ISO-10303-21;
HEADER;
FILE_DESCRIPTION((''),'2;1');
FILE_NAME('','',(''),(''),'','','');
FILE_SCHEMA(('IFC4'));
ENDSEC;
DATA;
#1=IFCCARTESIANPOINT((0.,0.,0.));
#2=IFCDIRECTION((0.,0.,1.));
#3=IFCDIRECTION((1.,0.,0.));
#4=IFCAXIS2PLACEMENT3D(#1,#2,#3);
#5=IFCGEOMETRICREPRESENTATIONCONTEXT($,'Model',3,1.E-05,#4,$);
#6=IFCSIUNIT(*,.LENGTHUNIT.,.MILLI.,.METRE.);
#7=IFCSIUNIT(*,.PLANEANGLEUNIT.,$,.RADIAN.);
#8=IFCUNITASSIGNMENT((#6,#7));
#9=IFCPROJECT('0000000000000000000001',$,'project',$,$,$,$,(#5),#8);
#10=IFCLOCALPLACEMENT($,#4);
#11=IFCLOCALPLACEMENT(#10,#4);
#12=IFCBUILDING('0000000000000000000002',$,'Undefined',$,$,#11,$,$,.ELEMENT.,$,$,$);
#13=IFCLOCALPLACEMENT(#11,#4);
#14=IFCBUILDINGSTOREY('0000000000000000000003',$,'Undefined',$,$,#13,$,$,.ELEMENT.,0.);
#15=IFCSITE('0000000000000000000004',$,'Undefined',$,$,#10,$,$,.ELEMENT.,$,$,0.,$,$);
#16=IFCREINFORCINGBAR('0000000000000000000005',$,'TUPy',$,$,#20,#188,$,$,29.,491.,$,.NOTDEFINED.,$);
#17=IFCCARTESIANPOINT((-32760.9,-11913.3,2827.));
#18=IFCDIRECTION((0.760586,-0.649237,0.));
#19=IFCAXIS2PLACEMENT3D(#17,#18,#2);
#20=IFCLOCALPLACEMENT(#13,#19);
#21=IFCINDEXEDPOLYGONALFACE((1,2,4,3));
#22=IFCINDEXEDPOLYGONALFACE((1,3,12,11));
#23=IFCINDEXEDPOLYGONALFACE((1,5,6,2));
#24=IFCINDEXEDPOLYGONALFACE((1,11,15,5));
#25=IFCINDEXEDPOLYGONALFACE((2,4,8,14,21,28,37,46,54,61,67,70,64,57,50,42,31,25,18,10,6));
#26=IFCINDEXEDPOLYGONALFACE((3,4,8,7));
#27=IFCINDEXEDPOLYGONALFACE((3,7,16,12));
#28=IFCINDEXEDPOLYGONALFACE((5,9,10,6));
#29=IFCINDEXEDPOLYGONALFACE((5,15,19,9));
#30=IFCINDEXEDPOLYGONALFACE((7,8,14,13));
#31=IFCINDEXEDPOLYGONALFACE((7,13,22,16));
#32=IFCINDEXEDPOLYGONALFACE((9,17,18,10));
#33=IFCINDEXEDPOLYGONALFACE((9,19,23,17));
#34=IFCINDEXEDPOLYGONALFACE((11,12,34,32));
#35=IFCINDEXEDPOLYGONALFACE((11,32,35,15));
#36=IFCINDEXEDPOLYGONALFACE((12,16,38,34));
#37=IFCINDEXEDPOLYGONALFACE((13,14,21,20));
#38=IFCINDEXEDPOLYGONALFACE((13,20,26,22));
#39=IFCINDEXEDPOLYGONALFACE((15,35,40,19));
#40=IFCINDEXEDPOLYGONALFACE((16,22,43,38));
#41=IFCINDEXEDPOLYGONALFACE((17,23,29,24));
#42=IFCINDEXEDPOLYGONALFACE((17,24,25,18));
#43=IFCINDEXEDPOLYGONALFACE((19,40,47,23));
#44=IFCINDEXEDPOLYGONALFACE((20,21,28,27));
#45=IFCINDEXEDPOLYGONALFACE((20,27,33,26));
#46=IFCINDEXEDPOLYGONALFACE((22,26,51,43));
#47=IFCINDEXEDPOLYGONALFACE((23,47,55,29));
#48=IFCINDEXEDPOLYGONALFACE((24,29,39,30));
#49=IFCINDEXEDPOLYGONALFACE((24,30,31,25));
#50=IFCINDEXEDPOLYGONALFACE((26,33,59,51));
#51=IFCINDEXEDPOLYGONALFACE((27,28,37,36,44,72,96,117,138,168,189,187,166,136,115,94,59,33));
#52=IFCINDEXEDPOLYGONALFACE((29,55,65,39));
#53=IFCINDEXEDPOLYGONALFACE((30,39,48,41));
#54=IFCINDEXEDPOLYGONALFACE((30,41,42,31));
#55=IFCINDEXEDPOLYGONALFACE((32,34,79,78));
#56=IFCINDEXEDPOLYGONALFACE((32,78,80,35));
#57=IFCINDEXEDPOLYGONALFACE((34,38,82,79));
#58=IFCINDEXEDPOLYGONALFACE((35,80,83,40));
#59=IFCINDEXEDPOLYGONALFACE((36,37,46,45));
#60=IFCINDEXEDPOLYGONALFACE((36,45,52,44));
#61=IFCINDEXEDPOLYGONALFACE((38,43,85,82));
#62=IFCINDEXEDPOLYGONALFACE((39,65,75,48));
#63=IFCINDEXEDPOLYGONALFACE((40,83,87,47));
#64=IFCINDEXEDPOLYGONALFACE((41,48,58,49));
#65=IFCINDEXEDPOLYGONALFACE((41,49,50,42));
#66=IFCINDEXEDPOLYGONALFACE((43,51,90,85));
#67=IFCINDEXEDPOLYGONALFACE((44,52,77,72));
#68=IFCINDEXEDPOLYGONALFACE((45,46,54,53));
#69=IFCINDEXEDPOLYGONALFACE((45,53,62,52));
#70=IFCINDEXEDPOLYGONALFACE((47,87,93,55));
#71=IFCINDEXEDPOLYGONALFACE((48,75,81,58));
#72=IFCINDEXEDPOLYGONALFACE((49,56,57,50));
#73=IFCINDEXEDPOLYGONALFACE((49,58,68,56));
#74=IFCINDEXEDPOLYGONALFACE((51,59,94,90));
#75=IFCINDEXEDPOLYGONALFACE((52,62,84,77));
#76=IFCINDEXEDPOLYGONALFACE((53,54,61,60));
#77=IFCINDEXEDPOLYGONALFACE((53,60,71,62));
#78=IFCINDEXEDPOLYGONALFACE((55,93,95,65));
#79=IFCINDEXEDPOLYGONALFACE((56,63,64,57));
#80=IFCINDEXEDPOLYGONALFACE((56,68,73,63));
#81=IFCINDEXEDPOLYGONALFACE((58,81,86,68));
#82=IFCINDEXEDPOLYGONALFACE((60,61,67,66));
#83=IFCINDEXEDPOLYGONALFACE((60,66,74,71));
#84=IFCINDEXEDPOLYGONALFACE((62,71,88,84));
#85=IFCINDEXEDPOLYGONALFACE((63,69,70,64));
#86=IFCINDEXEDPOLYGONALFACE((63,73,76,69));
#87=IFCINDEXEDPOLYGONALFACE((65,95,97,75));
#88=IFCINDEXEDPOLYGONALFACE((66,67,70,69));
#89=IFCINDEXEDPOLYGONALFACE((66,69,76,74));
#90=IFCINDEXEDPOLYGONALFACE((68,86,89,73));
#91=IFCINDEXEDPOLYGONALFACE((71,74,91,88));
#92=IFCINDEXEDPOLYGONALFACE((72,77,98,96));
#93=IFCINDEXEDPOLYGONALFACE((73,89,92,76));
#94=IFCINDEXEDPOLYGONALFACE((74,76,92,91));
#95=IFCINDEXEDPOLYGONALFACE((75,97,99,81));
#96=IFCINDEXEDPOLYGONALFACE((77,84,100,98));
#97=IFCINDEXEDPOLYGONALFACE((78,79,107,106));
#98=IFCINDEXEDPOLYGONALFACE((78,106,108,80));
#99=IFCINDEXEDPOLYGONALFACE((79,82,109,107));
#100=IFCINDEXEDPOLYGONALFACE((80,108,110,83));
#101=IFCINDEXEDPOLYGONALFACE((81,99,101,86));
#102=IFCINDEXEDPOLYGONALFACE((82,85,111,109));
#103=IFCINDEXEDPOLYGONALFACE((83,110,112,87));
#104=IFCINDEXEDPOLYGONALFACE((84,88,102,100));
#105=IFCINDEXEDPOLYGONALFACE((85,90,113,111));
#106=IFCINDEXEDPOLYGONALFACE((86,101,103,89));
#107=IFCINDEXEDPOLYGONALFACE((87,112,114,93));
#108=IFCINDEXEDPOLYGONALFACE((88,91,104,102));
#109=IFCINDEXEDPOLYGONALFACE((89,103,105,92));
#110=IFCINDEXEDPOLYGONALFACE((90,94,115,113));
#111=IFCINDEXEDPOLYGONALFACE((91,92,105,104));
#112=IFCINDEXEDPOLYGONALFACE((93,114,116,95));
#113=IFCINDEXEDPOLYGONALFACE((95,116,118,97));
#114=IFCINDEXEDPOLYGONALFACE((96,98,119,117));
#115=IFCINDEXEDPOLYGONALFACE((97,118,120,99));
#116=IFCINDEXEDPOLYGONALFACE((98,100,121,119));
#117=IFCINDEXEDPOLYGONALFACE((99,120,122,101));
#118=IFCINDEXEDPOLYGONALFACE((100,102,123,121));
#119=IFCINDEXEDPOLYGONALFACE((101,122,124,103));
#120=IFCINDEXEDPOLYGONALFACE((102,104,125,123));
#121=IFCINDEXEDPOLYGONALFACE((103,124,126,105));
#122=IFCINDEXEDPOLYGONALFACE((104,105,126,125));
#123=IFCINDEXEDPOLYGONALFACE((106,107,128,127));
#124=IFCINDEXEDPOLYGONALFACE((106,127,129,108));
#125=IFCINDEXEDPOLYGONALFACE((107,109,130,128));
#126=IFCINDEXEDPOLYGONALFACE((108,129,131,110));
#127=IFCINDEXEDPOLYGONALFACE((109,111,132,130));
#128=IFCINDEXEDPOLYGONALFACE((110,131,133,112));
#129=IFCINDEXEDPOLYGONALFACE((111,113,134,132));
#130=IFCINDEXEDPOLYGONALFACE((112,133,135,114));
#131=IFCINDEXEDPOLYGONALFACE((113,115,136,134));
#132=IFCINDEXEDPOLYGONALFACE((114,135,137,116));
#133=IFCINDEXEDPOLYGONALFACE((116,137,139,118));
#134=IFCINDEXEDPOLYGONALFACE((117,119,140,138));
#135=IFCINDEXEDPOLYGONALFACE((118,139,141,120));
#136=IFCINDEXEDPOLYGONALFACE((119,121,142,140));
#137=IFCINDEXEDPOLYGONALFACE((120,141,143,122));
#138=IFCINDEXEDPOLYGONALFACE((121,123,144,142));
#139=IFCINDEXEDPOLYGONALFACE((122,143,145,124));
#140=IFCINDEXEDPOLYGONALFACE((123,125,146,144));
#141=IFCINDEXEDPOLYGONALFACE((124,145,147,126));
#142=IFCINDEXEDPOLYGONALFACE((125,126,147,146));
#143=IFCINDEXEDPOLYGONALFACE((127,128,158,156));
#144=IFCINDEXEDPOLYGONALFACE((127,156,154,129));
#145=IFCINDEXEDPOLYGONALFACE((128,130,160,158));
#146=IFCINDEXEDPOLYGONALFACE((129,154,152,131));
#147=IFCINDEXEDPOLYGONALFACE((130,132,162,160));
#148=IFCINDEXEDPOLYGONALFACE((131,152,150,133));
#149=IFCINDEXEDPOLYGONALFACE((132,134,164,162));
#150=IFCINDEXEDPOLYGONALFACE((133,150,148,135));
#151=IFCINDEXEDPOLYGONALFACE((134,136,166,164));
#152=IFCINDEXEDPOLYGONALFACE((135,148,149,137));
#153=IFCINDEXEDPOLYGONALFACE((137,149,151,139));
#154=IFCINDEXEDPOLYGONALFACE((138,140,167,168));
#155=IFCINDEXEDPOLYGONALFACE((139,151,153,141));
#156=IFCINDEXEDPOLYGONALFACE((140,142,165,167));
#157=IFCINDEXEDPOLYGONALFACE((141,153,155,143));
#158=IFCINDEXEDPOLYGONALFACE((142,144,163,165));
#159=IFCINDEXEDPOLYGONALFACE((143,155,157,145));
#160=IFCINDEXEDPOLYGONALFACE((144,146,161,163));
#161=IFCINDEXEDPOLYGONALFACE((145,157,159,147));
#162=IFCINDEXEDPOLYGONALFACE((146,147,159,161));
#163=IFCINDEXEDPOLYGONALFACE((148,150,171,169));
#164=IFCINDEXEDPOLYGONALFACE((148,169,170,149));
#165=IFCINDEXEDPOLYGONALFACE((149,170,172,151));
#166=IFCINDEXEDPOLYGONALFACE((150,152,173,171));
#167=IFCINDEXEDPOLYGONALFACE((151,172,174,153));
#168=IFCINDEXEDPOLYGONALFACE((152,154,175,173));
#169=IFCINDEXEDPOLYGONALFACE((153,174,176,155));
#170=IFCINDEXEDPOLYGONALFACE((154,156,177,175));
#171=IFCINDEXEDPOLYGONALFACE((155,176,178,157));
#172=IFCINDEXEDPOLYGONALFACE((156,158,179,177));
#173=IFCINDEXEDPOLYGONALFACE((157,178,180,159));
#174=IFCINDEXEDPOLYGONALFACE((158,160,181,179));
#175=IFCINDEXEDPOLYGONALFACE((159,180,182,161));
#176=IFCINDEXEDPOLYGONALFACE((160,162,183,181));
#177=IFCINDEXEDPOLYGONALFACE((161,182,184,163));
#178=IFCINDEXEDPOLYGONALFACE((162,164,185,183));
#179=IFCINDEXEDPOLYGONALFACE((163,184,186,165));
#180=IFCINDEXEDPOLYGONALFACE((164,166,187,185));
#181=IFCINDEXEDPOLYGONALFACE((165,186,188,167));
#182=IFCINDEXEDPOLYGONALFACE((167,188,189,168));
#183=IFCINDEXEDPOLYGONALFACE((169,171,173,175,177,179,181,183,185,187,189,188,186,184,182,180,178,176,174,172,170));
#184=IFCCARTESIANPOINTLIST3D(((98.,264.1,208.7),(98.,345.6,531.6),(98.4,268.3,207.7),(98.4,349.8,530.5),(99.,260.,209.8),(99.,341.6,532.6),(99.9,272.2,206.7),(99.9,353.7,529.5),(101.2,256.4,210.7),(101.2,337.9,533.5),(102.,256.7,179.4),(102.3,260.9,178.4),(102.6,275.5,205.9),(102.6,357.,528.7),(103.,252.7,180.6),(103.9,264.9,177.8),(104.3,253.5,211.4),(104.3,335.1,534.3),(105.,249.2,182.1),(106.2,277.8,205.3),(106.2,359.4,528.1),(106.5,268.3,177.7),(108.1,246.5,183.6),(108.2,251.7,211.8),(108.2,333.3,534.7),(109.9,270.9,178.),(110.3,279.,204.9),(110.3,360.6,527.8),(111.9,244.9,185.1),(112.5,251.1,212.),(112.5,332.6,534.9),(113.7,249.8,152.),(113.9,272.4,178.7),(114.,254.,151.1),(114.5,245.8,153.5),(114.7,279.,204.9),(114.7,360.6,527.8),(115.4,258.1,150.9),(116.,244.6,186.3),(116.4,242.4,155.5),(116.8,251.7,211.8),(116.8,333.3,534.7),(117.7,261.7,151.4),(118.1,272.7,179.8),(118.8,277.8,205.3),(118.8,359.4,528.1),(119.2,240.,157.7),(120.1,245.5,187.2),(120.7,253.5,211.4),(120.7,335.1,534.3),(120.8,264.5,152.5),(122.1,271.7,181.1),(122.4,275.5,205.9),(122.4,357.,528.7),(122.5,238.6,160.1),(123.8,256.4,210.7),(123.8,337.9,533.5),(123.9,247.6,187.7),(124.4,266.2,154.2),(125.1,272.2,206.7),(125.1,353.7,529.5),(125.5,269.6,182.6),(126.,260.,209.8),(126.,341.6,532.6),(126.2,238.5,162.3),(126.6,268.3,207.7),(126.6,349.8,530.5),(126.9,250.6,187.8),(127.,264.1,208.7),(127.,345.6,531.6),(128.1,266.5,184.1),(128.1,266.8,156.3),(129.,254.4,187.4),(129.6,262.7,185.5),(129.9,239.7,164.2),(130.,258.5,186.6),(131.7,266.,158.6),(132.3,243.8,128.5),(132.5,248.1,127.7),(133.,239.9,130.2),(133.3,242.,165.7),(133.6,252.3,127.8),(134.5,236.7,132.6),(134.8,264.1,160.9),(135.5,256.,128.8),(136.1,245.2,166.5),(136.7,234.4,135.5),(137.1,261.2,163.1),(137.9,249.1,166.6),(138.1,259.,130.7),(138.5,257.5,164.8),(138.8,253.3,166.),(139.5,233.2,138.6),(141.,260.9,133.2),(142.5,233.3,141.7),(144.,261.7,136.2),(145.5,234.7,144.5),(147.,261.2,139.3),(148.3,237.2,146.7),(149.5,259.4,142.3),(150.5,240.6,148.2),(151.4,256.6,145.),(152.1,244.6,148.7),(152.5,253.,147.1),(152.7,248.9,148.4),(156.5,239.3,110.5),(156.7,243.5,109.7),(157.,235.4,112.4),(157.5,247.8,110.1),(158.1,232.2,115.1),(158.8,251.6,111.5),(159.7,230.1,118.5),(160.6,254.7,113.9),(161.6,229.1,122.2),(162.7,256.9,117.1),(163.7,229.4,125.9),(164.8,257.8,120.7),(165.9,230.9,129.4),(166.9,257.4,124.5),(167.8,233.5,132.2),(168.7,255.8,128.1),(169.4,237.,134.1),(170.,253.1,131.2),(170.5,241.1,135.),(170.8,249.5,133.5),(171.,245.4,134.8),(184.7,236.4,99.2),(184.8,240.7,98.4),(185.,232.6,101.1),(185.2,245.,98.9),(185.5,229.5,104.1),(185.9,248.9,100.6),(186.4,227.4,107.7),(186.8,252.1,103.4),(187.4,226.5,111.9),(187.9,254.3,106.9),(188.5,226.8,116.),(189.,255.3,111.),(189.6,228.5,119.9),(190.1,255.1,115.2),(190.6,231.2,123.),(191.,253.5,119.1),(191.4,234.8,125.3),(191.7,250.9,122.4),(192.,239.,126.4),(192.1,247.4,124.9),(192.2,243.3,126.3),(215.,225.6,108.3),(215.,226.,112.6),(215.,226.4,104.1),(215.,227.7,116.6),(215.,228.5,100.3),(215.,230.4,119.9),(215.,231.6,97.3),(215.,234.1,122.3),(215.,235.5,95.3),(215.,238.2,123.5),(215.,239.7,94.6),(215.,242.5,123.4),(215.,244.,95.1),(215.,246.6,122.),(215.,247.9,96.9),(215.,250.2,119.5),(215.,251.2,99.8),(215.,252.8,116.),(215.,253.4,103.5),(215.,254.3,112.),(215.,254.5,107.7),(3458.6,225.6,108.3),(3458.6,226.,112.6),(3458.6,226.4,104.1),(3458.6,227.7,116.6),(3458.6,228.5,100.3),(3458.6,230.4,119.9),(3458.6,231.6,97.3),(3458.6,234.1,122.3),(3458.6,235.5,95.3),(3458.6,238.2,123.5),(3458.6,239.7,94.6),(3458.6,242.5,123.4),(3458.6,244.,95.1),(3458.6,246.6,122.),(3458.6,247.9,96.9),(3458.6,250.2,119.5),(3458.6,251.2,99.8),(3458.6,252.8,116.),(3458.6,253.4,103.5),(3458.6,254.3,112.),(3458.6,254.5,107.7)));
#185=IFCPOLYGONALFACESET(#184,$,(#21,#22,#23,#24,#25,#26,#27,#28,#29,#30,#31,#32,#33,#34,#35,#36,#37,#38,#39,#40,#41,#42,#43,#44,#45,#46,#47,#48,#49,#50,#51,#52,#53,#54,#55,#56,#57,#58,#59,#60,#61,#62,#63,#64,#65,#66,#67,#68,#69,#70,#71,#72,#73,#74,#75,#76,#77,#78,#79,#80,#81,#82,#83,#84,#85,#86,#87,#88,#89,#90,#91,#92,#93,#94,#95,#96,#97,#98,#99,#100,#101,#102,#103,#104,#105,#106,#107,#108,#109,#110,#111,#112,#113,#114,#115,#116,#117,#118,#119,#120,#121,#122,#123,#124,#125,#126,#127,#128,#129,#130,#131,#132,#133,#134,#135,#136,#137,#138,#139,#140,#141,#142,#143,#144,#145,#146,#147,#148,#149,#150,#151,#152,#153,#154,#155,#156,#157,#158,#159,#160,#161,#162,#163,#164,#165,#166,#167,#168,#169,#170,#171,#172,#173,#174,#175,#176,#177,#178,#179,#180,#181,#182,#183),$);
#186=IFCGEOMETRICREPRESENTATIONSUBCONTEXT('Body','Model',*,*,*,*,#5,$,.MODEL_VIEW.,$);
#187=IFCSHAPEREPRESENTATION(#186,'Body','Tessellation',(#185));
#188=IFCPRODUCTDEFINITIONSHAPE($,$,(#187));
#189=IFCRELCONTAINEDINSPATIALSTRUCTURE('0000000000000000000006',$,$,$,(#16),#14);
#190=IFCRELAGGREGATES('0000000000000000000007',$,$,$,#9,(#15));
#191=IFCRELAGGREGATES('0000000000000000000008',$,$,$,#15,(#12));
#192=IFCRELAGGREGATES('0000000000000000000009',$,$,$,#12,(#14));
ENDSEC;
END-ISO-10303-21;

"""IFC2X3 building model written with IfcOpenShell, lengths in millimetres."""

from ifc_helpers import new_model, entity, si_unit, frame, origin_with_axes, place, context, subcontext, project, spatial, source, transform, mapped, element, save


model = new_model("IFC2X3")

# Units and contexts
model_context = context("Model", 3, precision=1e-05, world=origin_with_axes())
body_context = subcontext(model_context, "Body", "Model", "MODEL_VIEW")
ifc_project = project(units=[si_unit("LENGTHUNIT", "METRE", prefix="MILLI"), si_unit("PLANEANGLEUNIT", "RADIAN")], contexts=[model_context])

# Site, building, storey
site_placement = place(None, origin_with_axes())
site = spatial("IfcSite", under=ifc_project, at=site_placement, Name="Undefined", CompositionType="ELEMENT", RefElevation=0.0)
building_placement = place(site_placement, origin_with_axes())
building = spatial("IfcBuilding", under=site, at=building_placement, Name="Undefined", CompositionType="ELEMENT")
storey_placement = place(building_placement, origin_with_axes())
storey = spatial("IfcBuildingStorey", under=building, at=storey_placement, Name="Undefined", CompositionType="ELEMENT", Elevation=0.0)

# Reinforcing bar
shared_shape_1 = source(origin_with_axes(), body_context, "Body", "AdvancedSweptSolid", [
    entity("IfcSweptDiskSolid", entity("IfcCompositeCurve", [entity("IfcCompositeCurveSegment", "CONTINUOUS", True, entity("IfcTrimmedCurve", entity("IfcLine", entity("IfcCartesianPoint", [0.0, 0.0, 0.0]), entity("IfcVector", entity("IfcDirection", [0.0, -0.244871, -0.969556]), 1.0)), [entity("IfcParameterValue", 0.0)], [entity("IfcParameterValue", 333.0)], True, "PARAMETER")), entity("IfcCompositeCurveSegment", "CONTINUOUS", True, entity("IfcTrimmedCurve", entity("IfcCircle", entity("IfcAxis2Placement3D", entity("IfcCartesianPoint", [102.5, -81.5, -322.9]), entity("IfcDirection", [0.0, -0.969556, 0.244871]), entity("IfcDirection", [-1.0, 0.0, 0.0])), 102.5), [entity("IfcParameterValue", 0.0)], [entity("IfcParameterValue", 1.570796)], True, "PARAMETER")), entity("IfcCompositeCurveSegment", "DISCONTINUOUS", True, entity("IfcTrimmedCurve", entity("IfcLine", entity("IfcCartesianPoint", [102.5, -106.6, -422.2]), entity("IfcVector", entity("IfcDirection", [1.0, 0.0, 0.0]), 1.0)), [entity("IfcParameterValue", 0.0)], [entity("IfcParameterValue", 3243.607639)], True, "PARAMETER"))], False), 14.5, None, 0.0, 3578.2),
])
reinforcing_bar_1_placement = place(storey_placement, frame((-32760.9, -11913.3, 2827.0), z_axis=(0.760586, -0.649237, 0.0), x_axis=(0.0, 0.0, 1.0)))
element("IfcReinforcingBar", 1, at=reinforcing_bar_1_placement, inside=storey, Name="TUPy", BarRole="NOTDEFINED", CrossSectionArea=491.0, NominalDiameter=29.0, context=body_context, shape_type="MappedRepresentation", body=[
    mapped(shared_shape_1, transform((112.5, 346.7, 531.3))),
])

save(model, "model.ifc")
